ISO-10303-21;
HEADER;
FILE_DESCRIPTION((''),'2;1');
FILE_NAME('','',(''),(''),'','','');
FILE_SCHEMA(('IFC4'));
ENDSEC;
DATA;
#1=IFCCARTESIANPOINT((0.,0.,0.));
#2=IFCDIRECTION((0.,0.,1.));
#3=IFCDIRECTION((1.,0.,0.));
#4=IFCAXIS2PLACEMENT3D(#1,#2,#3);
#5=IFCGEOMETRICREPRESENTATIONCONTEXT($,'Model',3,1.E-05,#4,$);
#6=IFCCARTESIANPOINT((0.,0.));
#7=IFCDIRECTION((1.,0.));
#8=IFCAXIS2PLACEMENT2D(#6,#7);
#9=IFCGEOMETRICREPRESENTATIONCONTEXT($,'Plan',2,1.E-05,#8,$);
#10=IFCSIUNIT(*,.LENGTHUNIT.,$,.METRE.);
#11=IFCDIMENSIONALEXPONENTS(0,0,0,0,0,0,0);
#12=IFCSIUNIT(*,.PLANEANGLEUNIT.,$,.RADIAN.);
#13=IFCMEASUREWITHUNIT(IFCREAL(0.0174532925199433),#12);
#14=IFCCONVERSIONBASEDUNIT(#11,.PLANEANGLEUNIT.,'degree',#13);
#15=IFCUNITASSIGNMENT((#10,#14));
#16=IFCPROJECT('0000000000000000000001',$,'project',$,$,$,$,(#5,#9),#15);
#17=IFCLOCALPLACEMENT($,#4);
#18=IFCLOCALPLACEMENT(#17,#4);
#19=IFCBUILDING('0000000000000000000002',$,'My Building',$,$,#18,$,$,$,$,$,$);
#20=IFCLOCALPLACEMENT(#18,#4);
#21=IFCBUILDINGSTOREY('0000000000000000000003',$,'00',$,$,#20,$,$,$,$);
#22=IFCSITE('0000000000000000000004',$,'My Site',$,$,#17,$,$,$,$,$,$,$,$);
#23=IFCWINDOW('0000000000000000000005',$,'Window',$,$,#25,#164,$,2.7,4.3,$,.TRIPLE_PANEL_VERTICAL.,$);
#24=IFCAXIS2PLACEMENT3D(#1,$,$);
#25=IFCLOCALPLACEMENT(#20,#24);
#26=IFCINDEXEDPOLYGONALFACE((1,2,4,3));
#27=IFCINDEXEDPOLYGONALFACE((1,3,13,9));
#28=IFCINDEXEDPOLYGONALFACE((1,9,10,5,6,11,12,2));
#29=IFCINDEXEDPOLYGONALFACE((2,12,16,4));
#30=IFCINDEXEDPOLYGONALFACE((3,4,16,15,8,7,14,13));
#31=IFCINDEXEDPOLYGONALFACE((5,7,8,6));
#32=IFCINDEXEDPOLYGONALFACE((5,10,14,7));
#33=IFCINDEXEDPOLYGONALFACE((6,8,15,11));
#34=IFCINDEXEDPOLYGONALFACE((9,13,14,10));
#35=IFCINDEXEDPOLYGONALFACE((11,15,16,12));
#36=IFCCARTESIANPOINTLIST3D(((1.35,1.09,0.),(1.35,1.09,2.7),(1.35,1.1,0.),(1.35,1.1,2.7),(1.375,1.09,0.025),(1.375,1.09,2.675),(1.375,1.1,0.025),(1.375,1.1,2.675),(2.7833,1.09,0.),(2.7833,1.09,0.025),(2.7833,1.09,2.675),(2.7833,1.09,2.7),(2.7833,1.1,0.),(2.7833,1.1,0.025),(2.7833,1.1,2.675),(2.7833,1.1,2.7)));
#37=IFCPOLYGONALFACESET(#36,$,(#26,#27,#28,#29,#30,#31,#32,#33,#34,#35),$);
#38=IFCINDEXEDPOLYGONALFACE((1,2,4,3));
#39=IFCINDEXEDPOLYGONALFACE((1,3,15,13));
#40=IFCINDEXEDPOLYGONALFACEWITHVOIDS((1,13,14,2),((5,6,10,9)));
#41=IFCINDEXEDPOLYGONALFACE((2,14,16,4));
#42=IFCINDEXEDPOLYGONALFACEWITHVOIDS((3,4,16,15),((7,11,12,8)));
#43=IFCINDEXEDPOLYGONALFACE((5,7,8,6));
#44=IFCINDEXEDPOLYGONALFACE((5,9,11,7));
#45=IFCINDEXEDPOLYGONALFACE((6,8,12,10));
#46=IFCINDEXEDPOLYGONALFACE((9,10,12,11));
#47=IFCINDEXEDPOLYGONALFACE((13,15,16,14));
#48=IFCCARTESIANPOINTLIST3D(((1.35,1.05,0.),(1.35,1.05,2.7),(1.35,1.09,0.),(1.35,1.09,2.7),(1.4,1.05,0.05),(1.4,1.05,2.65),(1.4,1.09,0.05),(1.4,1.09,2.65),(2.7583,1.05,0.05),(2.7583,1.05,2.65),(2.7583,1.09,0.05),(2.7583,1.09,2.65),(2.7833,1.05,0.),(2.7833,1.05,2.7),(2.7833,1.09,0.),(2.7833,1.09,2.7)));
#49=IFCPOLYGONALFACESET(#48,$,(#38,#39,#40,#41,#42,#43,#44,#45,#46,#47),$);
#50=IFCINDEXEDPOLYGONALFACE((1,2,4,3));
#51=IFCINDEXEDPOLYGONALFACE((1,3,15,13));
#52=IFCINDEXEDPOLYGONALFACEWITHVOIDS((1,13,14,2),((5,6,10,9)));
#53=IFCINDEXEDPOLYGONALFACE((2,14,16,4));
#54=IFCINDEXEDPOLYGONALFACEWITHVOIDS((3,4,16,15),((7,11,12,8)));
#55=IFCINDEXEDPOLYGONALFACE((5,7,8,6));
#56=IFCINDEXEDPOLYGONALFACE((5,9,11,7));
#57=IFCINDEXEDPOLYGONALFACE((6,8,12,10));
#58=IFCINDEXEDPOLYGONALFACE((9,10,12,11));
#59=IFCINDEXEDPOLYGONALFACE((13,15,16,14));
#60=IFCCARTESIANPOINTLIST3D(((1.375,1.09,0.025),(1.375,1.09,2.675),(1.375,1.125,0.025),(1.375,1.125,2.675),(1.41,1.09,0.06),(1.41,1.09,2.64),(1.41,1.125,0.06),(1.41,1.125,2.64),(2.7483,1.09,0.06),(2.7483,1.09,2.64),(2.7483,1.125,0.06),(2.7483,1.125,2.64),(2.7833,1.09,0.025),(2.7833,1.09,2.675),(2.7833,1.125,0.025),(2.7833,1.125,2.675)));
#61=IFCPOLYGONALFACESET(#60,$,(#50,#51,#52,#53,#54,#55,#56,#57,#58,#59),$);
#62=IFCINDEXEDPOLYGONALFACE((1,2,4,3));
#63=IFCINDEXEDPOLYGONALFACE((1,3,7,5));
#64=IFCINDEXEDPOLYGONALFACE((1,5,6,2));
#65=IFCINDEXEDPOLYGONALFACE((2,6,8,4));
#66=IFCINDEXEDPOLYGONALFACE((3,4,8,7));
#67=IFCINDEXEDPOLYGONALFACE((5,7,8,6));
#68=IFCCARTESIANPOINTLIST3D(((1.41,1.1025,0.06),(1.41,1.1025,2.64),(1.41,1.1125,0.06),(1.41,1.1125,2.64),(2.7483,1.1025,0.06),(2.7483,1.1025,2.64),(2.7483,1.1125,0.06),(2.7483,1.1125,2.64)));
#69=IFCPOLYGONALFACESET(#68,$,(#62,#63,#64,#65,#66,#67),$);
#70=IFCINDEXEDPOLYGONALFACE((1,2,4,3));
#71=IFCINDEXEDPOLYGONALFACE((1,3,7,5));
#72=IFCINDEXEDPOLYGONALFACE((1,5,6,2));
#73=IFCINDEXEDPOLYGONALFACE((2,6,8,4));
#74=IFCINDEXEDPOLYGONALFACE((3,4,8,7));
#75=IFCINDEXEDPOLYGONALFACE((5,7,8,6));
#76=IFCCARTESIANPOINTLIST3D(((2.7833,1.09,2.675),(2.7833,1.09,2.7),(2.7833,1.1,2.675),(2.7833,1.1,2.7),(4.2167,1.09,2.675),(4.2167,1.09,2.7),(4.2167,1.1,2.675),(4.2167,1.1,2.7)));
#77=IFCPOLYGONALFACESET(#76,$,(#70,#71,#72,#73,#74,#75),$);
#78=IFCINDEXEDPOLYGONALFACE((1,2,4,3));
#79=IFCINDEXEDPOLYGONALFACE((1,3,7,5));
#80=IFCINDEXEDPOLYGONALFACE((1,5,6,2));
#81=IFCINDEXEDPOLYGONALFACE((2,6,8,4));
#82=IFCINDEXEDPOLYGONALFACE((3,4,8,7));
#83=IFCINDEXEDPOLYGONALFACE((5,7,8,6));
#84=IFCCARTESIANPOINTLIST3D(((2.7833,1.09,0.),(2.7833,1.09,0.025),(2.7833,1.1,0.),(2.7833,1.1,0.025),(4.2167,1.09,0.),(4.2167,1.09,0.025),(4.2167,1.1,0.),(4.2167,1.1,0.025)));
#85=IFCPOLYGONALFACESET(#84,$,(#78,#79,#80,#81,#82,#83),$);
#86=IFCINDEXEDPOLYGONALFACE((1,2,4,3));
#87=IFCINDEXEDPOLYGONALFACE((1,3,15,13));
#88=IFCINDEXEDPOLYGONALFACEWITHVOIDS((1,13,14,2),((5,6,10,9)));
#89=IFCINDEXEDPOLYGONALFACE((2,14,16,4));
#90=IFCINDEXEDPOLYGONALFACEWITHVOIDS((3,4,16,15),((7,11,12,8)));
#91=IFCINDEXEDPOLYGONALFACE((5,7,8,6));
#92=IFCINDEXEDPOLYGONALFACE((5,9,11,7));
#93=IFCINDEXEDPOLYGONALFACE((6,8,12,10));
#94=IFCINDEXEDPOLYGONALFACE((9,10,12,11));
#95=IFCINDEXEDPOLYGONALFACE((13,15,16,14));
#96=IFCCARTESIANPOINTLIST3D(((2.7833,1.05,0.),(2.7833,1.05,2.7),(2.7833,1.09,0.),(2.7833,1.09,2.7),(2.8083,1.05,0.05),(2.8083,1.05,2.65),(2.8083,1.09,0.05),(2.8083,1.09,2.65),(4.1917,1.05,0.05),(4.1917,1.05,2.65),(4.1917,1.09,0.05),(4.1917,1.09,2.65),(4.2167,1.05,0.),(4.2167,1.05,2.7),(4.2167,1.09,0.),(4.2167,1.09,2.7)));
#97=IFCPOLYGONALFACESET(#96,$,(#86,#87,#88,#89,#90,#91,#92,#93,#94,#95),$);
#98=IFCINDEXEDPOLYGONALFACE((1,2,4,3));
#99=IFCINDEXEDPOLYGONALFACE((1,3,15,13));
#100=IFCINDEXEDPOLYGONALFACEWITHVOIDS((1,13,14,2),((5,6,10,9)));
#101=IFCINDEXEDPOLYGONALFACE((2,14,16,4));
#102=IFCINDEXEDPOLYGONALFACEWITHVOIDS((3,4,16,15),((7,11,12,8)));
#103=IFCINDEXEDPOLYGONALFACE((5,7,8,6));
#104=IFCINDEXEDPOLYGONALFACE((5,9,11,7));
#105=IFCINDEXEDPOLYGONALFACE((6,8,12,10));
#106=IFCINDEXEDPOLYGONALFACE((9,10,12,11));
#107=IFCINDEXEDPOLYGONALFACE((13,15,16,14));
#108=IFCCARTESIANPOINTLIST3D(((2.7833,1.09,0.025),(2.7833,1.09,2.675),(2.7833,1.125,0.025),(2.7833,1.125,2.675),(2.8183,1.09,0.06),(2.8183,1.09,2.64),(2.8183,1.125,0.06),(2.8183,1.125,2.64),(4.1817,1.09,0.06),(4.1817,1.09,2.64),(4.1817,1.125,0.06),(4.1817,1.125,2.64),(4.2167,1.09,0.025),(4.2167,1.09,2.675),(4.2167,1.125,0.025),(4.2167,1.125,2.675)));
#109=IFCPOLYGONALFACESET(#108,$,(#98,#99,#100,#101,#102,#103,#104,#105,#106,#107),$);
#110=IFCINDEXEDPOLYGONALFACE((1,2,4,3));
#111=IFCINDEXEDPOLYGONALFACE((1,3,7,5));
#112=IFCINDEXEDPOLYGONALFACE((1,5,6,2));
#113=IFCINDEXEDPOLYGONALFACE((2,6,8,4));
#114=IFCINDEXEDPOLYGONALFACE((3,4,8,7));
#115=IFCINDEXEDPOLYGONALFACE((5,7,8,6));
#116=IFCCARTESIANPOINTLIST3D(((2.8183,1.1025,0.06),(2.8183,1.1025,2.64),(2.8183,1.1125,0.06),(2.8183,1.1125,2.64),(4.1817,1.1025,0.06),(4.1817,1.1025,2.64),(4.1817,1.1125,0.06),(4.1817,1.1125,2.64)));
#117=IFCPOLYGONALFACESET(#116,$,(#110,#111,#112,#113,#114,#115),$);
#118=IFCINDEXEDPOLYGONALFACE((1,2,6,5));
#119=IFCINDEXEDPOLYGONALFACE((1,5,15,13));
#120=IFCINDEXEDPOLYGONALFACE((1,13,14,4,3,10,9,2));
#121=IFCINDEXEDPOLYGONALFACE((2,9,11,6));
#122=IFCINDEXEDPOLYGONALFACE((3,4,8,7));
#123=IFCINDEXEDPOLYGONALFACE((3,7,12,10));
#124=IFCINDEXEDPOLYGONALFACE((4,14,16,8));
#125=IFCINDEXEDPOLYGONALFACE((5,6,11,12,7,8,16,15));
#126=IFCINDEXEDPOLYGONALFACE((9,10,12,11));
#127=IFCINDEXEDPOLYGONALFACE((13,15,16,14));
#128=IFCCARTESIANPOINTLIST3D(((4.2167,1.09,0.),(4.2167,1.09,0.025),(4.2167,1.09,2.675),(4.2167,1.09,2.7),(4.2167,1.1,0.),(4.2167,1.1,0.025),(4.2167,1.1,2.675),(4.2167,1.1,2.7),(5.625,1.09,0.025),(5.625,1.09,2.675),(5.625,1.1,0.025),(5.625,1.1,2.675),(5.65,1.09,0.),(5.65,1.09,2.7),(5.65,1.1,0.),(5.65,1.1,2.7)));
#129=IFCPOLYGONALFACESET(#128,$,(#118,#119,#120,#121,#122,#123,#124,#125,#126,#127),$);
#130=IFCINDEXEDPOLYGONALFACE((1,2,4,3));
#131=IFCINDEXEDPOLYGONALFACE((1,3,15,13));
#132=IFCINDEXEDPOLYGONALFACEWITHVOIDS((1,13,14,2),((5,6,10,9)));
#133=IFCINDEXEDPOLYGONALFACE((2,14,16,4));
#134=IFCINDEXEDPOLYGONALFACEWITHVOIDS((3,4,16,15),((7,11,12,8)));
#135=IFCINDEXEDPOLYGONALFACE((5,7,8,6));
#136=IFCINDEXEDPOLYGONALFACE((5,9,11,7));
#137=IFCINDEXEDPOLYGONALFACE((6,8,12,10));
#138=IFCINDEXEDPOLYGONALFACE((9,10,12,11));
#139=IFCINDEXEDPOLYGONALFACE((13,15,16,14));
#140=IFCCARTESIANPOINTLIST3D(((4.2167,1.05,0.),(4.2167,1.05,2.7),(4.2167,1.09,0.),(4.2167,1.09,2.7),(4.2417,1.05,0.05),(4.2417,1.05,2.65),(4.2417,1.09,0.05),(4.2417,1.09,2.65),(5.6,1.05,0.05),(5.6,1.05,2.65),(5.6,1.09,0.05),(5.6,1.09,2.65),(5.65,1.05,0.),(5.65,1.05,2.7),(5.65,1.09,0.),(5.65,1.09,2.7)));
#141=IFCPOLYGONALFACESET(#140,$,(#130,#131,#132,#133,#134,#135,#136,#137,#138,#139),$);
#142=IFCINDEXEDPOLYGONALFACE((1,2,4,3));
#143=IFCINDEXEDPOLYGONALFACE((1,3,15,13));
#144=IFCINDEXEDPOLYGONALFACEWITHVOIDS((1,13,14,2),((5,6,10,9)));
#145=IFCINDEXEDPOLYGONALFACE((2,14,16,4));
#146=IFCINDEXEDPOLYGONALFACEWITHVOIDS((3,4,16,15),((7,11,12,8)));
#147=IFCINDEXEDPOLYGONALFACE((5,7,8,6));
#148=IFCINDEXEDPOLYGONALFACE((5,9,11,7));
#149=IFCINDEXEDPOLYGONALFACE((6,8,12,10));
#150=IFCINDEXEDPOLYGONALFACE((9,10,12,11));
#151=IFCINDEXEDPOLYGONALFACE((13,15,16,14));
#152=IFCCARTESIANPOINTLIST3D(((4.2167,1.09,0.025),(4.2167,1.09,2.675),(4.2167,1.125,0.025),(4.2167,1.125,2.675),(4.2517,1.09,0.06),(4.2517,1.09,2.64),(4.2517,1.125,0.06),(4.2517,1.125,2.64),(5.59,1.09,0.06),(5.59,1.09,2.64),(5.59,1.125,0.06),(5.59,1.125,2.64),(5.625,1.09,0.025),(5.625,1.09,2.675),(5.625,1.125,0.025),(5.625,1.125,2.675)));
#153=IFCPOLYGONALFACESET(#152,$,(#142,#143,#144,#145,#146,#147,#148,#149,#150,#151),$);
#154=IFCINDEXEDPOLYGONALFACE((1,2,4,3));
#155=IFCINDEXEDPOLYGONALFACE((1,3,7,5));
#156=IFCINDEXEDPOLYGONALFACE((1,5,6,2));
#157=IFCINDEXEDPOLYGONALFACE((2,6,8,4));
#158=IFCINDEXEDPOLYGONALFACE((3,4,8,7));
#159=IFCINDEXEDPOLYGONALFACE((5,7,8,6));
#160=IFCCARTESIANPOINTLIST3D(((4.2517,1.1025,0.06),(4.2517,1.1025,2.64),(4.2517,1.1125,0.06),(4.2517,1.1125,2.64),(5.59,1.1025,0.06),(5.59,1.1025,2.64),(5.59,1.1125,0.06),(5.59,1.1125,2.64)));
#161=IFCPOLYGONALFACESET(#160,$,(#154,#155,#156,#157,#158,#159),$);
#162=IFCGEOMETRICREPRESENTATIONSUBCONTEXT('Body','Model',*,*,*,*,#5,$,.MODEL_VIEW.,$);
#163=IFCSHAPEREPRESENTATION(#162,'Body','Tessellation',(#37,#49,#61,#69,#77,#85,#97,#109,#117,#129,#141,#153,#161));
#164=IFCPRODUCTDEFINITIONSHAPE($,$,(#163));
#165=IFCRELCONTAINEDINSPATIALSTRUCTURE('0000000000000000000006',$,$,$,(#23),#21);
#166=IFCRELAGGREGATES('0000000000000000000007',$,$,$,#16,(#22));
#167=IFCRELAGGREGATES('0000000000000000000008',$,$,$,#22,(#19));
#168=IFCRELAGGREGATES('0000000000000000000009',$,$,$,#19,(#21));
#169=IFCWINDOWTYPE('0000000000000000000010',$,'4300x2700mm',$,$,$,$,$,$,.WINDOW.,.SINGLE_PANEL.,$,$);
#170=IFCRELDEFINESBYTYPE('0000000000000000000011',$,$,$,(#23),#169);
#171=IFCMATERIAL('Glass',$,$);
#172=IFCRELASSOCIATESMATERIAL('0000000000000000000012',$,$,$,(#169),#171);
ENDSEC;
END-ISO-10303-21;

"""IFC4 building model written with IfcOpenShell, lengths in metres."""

from ifc_helpers import new_model, entity, si_unit, converted_unit, frame, origin_with_axes, origin_2d_with_axis, place, context, subcontext, project, spatial, line, indexed_curve, outline, extrude, shape, source, transform, mapped, material, type_object, type_shapes, element, save


model = new_model("IFC4")

# Units and contexts
model_context = context("Model", 3, precision=1e-05, world=origin_with_axes())
plan_context = context("Plan", 2, precision=1e-05, world=origin_2d_with_axis())
body_context_1 = subcontext(model_context, "Body", "Model", "MODEL_VIEW")
body_context_2 = subcontext(plan_context, "Body", "Plan", "PLAN_VIEW")
ifc_project = project(units=[si_unit("LENGTHUNIT", "METRE"), converted_unit("PLANEANGLEUNIT", "degree", entity("IfcReal", 0.0174532925199433), si_unit("PLANEANGLEUNIT", "RADIAN"), dimensions=[0, 0, 0, 0, 0, 0, 0])], contexts=[model_context, plan_context])

# Site, building, storey
site_placement = place(None, origin_with_axes())
site = spatial("IfcSite", under=ifc_project, at=site_placement, Name="My Site")
building_placement = place(site_placement, origin_with_axes())
building = spatial("IfcBuilding", under=site, at=building_placement, Name="My Building")
storey_placement = place(building_placement, origin_with_axes())
storey = spatial("IfcBuildingStorey", under=building, at=storey_placement, Name="00")

# Shared definitions
ifc_material_1 = material(Name="Glass")

# Window
window_type_1 = type_object("IfcWindowType", Name="4300x2700mm", PartitioningType="SINGLE_PANEL", PredefinedType="WINDOW", material=ifc_material_1)
shared_shape_1 = source(origin_with_axes(), body_context_1, "Body", "SweptSolid", [
    extrude(outline(indexed_curve([(1.4333, 0.0), (0.0, 0.0), (0.0, 2.7), (1.4333, 2.7), (1.4333, 2.675), (0.025, 2.675), (0.025, 0.025), (1.4333, 0.025)], segments=[line(1, 2, 3, 4, 5, 6, 7, 8, 1)])), frame((0.0, 0.09, 0.0), z_axis=(0.0, -1.0, 0.0), x_axis=(1.0, 0.0, 0.0)), (0.0, 0.0, -1.0), 0.01),
    extrude(outline(indexed_curve([(0.0, 0.0), (1.4333, 0.0), (1.4333, 2.7), (0.0, 2.7)], segments=[line(1, 2, 3, 4, 1)]), holes=[indexed_curve([(0.05, 0.05), (1.4083, 0.05), (1.4083, 2.65), (0.05, 2.65)], segments=[line(1, 2, 3, 4, 1)])]), frame((0.0, 0.05, 0.0), z_axis=(0.0, -1.0, 0.0), x_axis=(1.0, 0.0, 0.0)), (0.0, 0.0, -1.0), 0.04),
    extrude(outline(indexed_curve([(0.0, 0.0), (1.4083, 0.0), (1.4083, 2.65), (0.0, 2.65)], segments=[line(1, 2, 3, 4, 1)]), holes=[indexed_curve([(0.035, 0.035), (1.3733, 0.035), (1.3733, 2.615), (0.035, 2.615)], segments=[line(1, 2, 3, 4, 1)])]), frame((0.025, 0.09, 0.025), z_axis=(0.0, -1.0, 0.0), x_axis=(1.0, 0.0, 0.0)), (0.0, 0.0, -1.0), 0.035),
    extrude(outline(indexed_curve([(0.035, 0.035), (1.3733, 0.035), (1.3733, 2.615), (0.035, 2.615)], segments=[line(1, 2, 3, 4, 1)])), frame((0.025, 0.1025, 0.025), z_axis=(0.0, -1.0, 0.0), x_axis=(1.0, 0.0, 0.0)), (0.0, 0.0, -1.0), 0.01),
    extrude(outline(indexed_curve([(0.0, 2.7), (1.4333, 2.7), (1.4333, 2.675), (0.0, 2.675)], segments=[line(1, 2, 3, 4, 1)])), frame((1.4333, 0.09, 0.0), z_axis=(0.0, -1.0, 0.0), x_axis=(1.0, 0.0, 0.0)), (0.0, 0.0, -1.0), 0.01),
    extrude(outline(indexed_curve([(1.4333, 0.0), (0.0, 0.0), (0.0, 0.025), (1.4333, 0.025)], segments=[line(1, 2, 3, 4, 1)])), frame((1.4333, 0.09, 0.0), z_axis=(0.0, -1.0, 0.0), x_axis=(1.0, 0.0, 0.0)), (0.0, 0.0, -1.0), 0.01),
    extrude(outline(indexed_curve([(0.0, 0.0), (1.4333, 0.0), (1.4333, 2.7), (0.0, 2.7)], segments=[line(1, 2, 3, 4, 1)]), holes=[indexed_curve([(0.025, 0.05), (1.4083, 0.05), (1.4083, 2.65), (0.025, 2.65)], segments=[line(1, 2, 3, 4, 1)])]), frame((1.4333, 0.05, 0.0), z_axis=(0.0, -1.0, 0.0), x_axis=(1.0, 0.0, 0.0)), (0.0, 0.0, -1.0), 0.04),
    extrude(outline(indexed_curve([(0.0, 0.0), (1.4333, 0.0), (1.4333, 2.65), (0.0, 2.65)], segments=[line(1, 2, 3, 4, 1)]), holes=[indexed_curve([(0.035, 0.035), (1.3983, 0.035), (1.3983, 2.615), (0.035, 2.615)], segments=[line(1, 2, 3, 4, 1)])]), frame((1.4333, 0.09, 0.025), z_axis=(0.0, -1.0, 0.0), x_axis=(1.0, 0.0, 0.0)), (0.0, 0.0, -1.0), 0.035),
    extrude(outline(indexed_curve([(0.035, 0.035), (1.3983, 0.035), (1.3983, 2.615), (0.035, 2.615)], segments=[line(1, 2, 3, 4, 1)])), frame((1.4333, 0.1025, 0.025), z_axis=(0.0, -1.0, 0.0), x_axis=(1.0, 0.0, 0.0)), (0.0, 0.0, -1.0), 0.01),
    extrude(outline(indexed_curve([(0.0, 2.7), (1.4333, 2.7), (1.4333, 0.0), (0.0, 0.0), (0.0, 0.025), (1.4083, 0.025), (1.4083, 2.675), (0.0, 2.675)], segments=[line(1, 2, 3, 4, 5, 6, 7, 8, 1)])), frame((2.8667, 0.09, 0.0), z_axis=(0.0, -1.0, 0.0), x_axis=(1.0, 0.0, 0.0)), (0.0, 0.0, -1.0), 0.01),
    extrude(outline(indexed_curve([(0.0, 0.0), (1.4333, 0.0), (1.4333, 2.7), (0.0, 2.7)], segments=[line(1, 2, 3, 4, 1)]), holes=[indexed_curve([(0.025, 0.05), (1.3833, 0.05), (1.3833, 2.65), (0.025, 2.65)], segments=[line(1, 2, 3, 4, 1)])]), frame((2.8667, 0.05, 0.0), z_axis=(0.0, -1.0, 0.0), x_axis=(1.0, 0.0, 0.0)), (0.0, 0.0, -1.0), 0.04),
    extrude(outline(indexed_curve([(0.0, 0.0), (1.4083, 0.0), (1.4083, 2.65), (0.0, 2.65)], segments=[line(1, 2, 3, 4, 1)]), holes=[indexed_curve([(0.035, 0.035), (1.3733, 0.035), (1.3733, 2.615), (0.035, 2.615)], segments=[line(1, 2, 3, 4, 1)])]), frame((2.8667, 0.09, 0.025), z_axis=(0.0, -1.0, 0.0), x_axis=(1.0, 0.0, 0.0)), (0.0, 0.0, -1.0), 0.035),
    extrude(outline(indexed_curve([(0.035, 0.035), (1.3733, 0.035), (1.3733, 2.615), (0.035, 2.615)], segments=[line(1, 2, 3, 4, 1)])), frame((2.8667, 0.1025, 0.025), z_axis=(0.0, -1.0, 0.0), x_axis=(1.0, 0.0, 0.0)), (0.0, 0.0, -1.0), 0.01),
])
shared_shape_2 = source(origin_with_axes(), body_context_2, "Body", "Curve2D", [
    entity("IfcIndexedPolyCurve", entity("IfcCartesianPointList2D", [[0.05, 0.05], [1.4083, 0.05]])),
    entity("IfcIndexedPolyCurve", entity("IfcCartesianPointList2D", [[0.0, 0.1], [0.025, 0.1], [0.025, 0.09], [0.05, 0.09], [0.05, 0.05], [0.0, 0.05]]), [entity("IfcLineIndex", [1, 2, 3, 4, 5, 6, 1])]),
    entity("IfcIndexedPolyCurve", entity("IfcCartesianPointList2D", [[1.4333, 0.1], [1.4333, 0.1], [1.4333, 0.09], [1.4083, 0.09], [1.4083, 0.05], [1.4333, 0.05]])),
    entity("IfcIndexedPolyCurve", entity("IfcCartesianPointList2D", [[0.025, 0.09], [0.06, 0.09], [0.06, 0.125], [0.025, 0.125]]), [entity("IfcLineIndex", [1, 2, 3, 4, 1])]),
    entity("IfcIndexedPolyCurve", entity("IfcCartesianPointList2D", [[1.4333, 0.09], [1.3983, 0.09], [1.3983, 0.125], [1.4333, 0.125]]), [entity("IfcLineIndex", [1, 2, 3, 4, 1])]),
    entity("IfcIndexedPolyCurve", entity("IfcCartesianPointList2D", [[0.06, 0.09], [1.3983, 0.09]])),
    entity("IfcIndexedPolyCurve", entity("IfcCartesianPointList2D", [[0.06, 0.125], [1.3983, 0.125]])),
    entity("IfcIndexedPolyCurve", entity("IfcCartesianPointList2D", [[0.06, 0.1075], [1.3983, 0.1075]])),
    entity("IfcIndexedPolyCurve", entity("IfcCartesianPointList2D", [[1.4583, 0.05], [2.8417, 0.05]])),
    entity("IfcIndexedPolyCurve", entity("IfcCartesianPointList2D", [[1.4333, 0.1], [1.4333, 0.1], [1.4333, 0.09], [1.4583, 0.09], [1.4583, 0.05], [1.4333, 0.05]])),
    entity("IfcIndexedPolyCurve", entity("IfcCartesianPointList2D", [[2.8667, 0.1], [2.8667, 0.1], [2.8667, 0.09], [2.8417, 0.09], [2.8417, 0.05], [2.8667, 0.05]])),
    entity("IfcIndexedPolyCurve", entity("IfcCartesianPointList2D", [[1.4333, 0.09], [1.4683, 0.09], [1.4683, 0.125], [1.4333, 0.125]]), [entity("IfcLineIndex", [1, 2, 3, 4, 1])]),
    entity("IfcIndexedPolyCurve", entity("IfcCartesianPointList2D", [[2.8667, 0.09], [2.8317, 0.09], [2.8317, 0.125], [2.8667, 0.125]]), [entity("IfcLineIndex", [1, 2, 3, 4, 1])]),
    entity("IfcIndexedPolyCurve", entity("IfcCartesianPointList2D", [[1.4683, 0.09], [2.8317, 0.09]])),
    entity("IfcIndexedPolyCurve", entity("IfcCartesianPointList2D", [[1.4683, 0.125], [2.8317, 0.125]])),
    entity("IfcIndexedPolyCurve", entity("IfcCartesianPointList2D", [[1.4683, 0.1075], [2.8317, 0.1075]])),
    entity("IfcIndexedPolyCurve", entity("IfcCartesianPointList2D", [[2.8917, 0.05], [4.25, 0.05]])),
    entity("IfcIndexedPolyCurve", entity("IfcCartesianPointList2D", [[2.8667, 0.1], [2.8667, 0.1], [2.8667, 0.09], [2.8917, 0.09], [2.8917, 0.05], [2.8667, 0.05]])),
    entity("IfcIndexedPolyCurve", entity("IfcCartesianPointList2D", [[4.3, 0.1], [4.275, 0.1], [4.275, 0.09], [4.25, 0.09], [4.25, 0.05], [4.3, 0.05]]), [entity("IfcLineIndex", [1, 2, 3, 4, 5, 6, 1])]),
    entity("IfcIndexedPolyCurve", entity("IfcCartesianPointList2D", [[2.8667, 0.09], [2.9017, 0.09], [2.9017, 0.125], [2.8667, 0.125]]), [entity("IfcLineIndex", [1, 2, 3, 4, 1])]),
    entity("IfcIndexedPolyCurve", entity("IfcCartesianPointList2D", [[4.275, 0.09], [4.24, 0.09], [4.24, 0.125], [4.275, 0.125]]), [entity("IfcLineIndex", [1, 2, 3, 4, 1])]),
    entity("IfcIndexedPolyCurve", entity("IfcCartesianPointList2D", [[2.9017, 0.09], [4.24, 0.09]])),
    entity("IfcIndexedPolyCurve", entity("IfcCartesianPointList2D", [[2.9017, 0.125], [4.24, 0.125]])),
    entity("IfcIndexedPolyCurve", entity("IfcCartesianPointList2D", [[2.9017, 0.1075], [4.24, 0.1075]])),
])
type_shapes(window_type_1, [shared_shape_1, shared_shape_2])
window_1_placement = place(storey_placement, frame((1.35, 1.0, 0.0), z_axis=(0.0, 0.0, 1.0), x_axis=(1.0, 0.0, 0.0)))
element("IfcWindow", 1, at=window_1_placement, inside=storey, type_object=window_type_1, Name="Window", OverallHeight=2.7, OverallWidth=4.3, PartitioningType="TRIPLE_PANEL_VERTICAL", shapes=[
    shape(body_context_1, "Body", "MappedRepresentation", [mapped(shared_shape_1, transform((0.0, 0.0, 0.0), x_axis=(1.0, 0.0, 0.0), y_axis=(0.0, 1.0, 0.0), z_axis=(0.0, 0.0, 1.0), scale=1.0))]),
    shape(body_context_2, "Body", "MappedRepresentation", [mapped(shared_shape_2, transform((0.0, 0.0, 0.0), x_axis=(1.0, 0.0, 0.0), y_axis=(0.0, 1.0, 0.0), z_axis=(0.0, 0.0, 1.0), scale=1.0))]),
])

save(model, "model.ifc")
